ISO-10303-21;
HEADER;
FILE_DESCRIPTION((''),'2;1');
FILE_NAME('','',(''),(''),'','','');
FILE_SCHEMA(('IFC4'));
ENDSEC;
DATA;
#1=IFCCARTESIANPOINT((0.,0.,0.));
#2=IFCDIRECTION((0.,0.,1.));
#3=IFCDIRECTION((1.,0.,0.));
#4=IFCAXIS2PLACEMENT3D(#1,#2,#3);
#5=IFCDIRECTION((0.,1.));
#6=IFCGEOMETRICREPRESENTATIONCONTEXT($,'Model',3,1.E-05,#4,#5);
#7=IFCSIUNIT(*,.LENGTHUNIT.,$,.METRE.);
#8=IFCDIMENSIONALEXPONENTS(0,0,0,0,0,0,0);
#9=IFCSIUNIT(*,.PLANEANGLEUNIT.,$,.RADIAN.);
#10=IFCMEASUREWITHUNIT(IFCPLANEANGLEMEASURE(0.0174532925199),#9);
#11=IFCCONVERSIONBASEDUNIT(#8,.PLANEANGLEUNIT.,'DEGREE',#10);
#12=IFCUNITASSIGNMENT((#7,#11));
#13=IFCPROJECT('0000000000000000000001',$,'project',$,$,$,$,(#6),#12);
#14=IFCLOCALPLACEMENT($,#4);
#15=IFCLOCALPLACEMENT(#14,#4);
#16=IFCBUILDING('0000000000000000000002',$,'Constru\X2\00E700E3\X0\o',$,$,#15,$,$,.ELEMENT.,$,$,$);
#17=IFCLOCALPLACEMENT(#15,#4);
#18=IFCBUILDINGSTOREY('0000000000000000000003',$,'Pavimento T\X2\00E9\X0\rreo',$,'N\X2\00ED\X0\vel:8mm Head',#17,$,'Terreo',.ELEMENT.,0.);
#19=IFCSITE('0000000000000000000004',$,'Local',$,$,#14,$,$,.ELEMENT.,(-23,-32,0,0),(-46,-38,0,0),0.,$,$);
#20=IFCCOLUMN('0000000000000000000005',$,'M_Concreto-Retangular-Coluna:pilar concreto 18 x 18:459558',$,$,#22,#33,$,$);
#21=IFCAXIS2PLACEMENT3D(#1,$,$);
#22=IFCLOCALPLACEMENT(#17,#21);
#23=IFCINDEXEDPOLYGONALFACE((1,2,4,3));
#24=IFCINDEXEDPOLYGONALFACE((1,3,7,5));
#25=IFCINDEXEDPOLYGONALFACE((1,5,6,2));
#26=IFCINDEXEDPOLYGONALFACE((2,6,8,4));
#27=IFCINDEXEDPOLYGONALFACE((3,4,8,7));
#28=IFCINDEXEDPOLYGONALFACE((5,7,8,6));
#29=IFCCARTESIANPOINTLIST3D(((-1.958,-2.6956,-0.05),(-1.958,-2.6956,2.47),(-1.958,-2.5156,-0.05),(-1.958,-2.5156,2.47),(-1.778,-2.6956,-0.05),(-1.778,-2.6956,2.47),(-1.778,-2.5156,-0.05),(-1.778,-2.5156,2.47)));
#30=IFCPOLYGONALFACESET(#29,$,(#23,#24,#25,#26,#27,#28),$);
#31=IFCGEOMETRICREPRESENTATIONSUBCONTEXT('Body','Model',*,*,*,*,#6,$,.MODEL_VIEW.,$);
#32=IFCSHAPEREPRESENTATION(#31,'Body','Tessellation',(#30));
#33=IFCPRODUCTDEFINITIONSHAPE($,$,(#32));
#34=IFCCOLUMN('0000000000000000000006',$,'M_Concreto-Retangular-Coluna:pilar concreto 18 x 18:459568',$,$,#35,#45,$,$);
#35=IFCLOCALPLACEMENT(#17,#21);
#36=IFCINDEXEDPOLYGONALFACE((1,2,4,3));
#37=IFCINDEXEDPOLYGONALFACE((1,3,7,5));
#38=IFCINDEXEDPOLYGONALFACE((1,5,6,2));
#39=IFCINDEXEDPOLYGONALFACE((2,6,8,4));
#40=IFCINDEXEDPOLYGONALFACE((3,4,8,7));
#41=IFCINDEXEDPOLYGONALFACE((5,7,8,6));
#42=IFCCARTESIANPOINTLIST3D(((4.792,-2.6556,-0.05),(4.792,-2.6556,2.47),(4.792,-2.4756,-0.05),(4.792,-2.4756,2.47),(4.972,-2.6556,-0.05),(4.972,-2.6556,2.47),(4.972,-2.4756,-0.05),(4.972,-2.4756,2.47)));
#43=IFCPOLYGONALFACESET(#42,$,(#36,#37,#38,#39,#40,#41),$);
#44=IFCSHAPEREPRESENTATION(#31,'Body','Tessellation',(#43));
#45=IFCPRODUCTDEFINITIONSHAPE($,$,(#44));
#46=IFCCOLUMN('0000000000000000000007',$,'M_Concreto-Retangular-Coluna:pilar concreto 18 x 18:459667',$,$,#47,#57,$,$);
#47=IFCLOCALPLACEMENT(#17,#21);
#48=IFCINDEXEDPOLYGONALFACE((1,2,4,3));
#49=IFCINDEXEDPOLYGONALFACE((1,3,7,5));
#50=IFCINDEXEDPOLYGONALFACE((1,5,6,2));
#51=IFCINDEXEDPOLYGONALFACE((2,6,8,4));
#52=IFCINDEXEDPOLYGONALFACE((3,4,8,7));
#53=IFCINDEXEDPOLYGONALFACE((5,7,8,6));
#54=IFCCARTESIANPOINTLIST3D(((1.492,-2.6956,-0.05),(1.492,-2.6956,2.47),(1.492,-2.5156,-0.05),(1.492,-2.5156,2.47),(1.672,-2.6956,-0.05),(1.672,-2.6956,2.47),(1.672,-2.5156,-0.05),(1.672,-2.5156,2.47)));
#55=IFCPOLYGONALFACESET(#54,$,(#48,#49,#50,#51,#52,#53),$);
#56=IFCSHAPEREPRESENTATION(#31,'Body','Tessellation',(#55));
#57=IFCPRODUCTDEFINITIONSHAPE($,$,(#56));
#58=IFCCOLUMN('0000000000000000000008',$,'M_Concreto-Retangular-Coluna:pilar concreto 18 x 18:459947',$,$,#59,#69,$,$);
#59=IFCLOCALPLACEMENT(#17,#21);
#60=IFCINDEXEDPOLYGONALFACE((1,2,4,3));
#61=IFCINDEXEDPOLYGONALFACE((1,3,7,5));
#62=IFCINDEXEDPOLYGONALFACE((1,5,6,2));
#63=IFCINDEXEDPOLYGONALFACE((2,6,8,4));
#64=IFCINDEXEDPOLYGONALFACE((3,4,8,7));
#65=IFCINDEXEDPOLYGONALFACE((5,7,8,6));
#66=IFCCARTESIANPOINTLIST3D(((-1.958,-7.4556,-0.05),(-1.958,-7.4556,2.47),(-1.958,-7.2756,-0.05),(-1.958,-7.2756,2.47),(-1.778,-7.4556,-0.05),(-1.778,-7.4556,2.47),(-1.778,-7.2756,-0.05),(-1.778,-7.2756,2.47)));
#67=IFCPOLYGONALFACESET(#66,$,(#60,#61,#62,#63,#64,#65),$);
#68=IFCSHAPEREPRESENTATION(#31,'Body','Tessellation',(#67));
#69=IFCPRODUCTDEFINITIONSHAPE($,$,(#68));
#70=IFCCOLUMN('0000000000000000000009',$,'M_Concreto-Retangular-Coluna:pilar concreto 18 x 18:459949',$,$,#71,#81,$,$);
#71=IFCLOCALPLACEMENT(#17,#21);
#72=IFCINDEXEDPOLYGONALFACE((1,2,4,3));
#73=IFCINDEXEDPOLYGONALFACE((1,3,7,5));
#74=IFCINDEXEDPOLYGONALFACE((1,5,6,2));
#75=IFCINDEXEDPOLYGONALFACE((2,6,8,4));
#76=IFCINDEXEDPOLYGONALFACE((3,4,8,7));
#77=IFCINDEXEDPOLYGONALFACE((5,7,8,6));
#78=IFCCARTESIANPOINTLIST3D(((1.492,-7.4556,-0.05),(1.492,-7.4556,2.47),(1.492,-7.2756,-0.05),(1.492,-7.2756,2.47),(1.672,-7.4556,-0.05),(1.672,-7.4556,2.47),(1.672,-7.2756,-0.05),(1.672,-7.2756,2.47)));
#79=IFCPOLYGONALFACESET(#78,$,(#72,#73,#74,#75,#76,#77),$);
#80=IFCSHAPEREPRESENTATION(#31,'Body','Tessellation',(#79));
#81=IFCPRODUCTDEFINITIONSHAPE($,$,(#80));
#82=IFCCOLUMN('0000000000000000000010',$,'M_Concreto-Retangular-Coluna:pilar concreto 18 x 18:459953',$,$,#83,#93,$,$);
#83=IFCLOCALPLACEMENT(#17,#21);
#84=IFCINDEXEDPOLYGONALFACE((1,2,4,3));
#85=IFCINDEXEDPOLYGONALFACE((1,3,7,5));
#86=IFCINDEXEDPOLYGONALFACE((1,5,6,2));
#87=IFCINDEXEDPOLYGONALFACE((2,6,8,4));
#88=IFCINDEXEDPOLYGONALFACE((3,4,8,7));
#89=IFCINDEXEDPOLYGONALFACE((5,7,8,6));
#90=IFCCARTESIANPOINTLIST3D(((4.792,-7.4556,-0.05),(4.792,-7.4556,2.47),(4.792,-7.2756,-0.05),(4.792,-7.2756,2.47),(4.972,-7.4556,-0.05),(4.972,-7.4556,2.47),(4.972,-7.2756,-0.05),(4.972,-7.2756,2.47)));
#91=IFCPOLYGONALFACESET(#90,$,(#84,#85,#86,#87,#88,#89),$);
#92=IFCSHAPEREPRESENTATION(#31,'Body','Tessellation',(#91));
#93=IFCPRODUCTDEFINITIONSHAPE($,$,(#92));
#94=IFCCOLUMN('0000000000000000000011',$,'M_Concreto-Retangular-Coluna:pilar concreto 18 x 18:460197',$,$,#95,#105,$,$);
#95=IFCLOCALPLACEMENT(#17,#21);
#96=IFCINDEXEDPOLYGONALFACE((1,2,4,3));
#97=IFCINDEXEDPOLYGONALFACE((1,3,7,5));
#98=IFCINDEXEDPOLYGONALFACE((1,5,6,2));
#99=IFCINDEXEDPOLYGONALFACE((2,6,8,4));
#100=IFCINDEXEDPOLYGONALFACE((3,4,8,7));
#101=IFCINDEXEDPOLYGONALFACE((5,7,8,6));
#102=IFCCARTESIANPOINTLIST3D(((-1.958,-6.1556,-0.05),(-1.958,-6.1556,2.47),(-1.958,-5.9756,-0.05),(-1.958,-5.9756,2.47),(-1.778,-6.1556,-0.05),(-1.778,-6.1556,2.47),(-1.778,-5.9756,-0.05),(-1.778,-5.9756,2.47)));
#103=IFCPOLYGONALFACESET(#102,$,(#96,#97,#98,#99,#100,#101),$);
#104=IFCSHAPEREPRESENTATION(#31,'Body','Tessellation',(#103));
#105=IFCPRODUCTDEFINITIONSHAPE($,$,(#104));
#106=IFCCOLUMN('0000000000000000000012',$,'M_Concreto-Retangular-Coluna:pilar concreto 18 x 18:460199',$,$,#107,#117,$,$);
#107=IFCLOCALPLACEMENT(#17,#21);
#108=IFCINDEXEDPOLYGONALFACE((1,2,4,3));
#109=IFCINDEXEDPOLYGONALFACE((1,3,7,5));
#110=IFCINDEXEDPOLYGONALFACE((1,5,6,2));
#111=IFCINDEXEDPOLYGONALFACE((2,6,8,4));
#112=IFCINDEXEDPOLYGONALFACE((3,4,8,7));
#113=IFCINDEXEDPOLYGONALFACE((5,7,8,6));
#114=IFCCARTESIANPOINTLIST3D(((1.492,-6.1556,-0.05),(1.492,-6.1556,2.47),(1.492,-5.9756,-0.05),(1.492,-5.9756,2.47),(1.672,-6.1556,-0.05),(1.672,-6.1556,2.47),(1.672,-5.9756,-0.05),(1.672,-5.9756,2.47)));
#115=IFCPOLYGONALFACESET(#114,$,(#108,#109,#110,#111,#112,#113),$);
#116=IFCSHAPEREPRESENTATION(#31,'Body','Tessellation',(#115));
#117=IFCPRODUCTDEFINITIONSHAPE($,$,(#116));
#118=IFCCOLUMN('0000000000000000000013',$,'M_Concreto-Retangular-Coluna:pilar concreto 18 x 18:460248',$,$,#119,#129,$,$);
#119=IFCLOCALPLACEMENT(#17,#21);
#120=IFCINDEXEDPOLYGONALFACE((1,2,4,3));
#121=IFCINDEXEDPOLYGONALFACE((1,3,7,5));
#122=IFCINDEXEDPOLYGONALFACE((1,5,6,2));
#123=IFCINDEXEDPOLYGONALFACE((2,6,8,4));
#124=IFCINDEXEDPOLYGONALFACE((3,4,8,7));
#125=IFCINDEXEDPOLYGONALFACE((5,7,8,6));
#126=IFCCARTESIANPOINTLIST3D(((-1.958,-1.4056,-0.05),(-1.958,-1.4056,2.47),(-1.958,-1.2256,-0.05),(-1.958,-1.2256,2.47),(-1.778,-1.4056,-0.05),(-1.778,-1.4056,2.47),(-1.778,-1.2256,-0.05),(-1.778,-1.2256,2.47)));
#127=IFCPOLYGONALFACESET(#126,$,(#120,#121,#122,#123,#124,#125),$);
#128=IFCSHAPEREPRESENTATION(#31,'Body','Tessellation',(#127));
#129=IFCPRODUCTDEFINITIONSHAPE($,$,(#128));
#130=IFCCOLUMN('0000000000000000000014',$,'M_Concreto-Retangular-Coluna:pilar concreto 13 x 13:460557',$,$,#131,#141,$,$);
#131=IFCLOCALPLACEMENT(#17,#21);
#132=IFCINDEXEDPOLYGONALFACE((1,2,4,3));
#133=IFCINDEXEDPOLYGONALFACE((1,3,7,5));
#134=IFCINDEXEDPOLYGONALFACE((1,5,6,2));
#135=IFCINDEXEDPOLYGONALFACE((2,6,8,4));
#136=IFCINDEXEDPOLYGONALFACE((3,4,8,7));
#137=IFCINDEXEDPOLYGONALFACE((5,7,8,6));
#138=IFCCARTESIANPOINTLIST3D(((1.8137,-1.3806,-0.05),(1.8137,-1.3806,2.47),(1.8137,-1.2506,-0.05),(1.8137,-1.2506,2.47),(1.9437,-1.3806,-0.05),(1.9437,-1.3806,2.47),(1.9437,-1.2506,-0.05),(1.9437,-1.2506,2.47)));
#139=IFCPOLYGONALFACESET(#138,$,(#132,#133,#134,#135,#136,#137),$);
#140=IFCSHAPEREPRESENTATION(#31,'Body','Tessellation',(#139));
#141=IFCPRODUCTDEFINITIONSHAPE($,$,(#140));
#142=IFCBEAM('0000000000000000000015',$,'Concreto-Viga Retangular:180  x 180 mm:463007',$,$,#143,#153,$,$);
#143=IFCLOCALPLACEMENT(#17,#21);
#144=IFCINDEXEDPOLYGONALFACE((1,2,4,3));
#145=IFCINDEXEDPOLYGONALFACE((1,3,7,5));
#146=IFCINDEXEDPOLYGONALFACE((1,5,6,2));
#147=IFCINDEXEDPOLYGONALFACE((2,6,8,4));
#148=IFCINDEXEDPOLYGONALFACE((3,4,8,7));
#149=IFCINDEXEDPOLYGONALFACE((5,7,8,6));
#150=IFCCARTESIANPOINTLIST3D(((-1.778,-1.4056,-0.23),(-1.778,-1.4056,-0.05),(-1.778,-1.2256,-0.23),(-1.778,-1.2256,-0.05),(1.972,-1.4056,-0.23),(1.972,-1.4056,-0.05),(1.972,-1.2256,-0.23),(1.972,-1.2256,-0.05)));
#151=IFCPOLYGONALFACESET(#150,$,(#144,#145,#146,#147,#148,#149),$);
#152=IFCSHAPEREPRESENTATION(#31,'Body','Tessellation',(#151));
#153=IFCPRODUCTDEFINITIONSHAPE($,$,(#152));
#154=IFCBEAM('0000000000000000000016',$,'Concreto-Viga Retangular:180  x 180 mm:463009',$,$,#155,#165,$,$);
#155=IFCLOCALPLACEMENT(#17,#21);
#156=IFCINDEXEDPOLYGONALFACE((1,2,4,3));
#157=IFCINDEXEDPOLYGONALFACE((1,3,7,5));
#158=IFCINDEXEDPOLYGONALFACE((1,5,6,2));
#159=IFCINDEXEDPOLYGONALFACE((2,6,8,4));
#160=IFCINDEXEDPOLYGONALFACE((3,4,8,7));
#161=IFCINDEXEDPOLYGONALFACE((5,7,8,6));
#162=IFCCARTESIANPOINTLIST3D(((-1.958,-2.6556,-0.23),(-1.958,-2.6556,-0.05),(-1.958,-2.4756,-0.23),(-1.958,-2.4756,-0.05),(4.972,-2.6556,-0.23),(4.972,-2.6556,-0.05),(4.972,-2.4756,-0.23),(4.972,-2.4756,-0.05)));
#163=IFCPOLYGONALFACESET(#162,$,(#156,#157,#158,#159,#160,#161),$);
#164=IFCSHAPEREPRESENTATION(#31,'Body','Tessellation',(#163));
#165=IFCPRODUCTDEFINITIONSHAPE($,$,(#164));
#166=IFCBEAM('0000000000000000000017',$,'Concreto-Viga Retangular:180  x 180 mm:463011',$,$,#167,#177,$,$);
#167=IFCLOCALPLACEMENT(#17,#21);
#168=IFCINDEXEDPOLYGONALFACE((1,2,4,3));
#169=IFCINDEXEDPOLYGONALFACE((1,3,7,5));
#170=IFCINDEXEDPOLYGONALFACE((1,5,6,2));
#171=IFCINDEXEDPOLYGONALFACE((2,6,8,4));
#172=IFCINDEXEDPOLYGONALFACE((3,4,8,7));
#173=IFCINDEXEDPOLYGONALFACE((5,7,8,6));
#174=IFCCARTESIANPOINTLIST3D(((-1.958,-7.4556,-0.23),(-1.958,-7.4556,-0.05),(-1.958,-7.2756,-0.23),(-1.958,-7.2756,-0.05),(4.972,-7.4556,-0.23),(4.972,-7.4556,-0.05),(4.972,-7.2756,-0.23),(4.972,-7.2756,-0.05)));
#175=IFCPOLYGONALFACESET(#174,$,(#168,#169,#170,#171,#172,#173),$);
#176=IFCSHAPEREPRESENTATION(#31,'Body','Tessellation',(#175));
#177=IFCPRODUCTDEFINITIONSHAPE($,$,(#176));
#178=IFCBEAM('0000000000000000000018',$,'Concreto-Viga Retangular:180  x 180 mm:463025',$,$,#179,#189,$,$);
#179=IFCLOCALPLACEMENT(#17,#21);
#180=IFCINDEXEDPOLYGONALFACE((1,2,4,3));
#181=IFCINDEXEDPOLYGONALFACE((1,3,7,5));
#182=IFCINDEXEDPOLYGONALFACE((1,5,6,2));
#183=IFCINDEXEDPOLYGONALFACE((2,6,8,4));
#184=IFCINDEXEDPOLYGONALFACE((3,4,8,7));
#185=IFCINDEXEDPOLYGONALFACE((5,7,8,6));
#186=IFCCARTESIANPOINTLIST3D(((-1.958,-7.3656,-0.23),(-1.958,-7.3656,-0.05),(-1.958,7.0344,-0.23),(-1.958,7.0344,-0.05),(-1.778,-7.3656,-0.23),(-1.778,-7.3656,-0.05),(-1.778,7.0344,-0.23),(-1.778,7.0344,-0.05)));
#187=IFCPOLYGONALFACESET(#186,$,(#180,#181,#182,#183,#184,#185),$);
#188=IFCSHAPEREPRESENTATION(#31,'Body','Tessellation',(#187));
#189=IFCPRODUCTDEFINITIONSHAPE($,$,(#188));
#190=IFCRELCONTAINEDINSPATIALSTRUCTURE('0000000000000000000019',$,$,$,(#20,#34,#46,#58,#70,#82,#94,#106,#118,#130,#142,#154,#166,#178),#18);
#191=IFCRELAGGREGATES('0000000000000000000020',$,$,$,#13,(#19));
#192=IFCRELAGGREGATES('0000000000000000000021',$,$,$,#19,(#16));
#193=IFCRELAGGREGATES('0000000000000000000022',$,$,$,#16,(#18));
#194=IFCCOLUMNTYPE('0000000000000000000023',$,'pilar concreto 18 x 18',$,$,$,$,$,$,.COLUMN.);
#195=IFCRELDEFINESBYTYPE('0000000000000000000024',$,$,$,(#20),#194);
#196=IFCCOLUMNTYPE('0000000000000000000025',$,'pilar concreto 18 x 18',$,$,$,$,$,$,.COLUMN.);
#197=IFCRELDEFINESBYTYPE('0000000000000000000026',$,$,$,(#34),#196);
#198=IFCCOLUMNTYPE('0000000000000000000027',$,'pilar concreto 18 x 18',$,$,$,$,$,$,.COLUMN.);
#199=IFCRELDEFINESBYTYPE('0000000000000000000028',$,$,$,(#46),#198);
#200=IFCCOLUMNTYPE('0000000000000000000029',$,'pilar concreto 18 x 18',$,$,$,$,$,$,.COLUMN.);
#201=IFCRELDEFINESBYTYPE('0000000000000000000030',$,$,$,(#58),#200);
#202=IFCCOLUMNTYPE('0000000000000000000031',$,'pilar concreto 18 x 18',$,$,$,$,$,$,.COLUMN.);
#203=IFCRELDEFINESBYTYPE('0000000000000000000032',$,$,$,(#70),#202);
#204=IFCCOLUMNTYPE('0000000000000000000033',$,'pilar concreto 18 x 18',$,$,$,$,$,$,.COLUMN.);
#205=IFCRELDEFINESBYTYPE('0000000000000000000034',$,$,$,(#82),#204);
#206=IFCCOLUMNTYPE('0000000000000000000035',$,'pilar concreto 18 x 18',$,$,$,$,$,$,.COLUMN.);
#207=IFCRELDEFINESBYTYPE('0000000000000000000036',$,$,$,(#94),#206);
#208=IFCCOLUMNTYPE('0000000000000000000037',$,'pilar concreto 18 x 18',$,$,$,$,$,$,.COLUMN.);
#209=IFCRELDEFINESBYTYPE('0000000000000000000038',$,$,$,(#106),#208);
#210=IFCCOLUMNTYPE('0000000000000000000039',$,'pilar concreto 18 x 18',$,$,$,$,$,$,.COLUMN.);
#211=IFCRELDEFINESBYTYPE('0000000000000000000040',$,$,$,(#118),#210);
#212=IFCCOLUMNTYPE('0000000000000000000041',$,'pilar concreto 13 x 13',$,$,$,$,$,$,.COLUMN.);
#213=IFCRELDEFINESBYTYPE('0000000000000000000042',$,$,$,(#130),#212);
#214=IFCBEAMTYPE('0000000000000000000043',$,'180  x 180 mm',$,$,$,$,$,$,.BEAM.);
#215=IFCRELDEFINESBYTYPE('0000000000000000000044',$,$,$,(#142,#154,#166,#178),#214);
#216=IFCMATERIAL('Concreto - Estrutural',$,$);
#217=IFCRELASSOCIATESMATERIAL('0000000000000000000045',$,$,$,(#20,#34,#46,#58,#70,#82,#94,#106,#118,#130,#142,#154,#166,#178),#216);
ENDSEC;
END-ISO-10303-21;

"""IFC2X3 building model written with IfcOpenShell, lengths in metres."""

from ifc_helpers import new_model, entity, si_unit, converted_unit, direction, frame, frame_2d, origin_with_axes, origin_2d_with_axis, place, context, subcontext, project, spatial, rectangle, extrude, material, type_object, element, save


model = new_model("IFC2X3")

# Units and contexts
model_context = context("Model", 3, precision=1e-05, world=origin_with_axes(), true_north=direction((0.0, 1.0)))
body_context = subcontext(model_context, "Body", "Model", "MODEL_VIEW")
ifc_project = project(units=[si_unit("LENGTHUNIT", "METRE"), converted_unit("PLANEANGLEUNIT", "DEGREE", entity("IfcPlaneAngleMeasure", 0.0174532925199), si_unit("PLANEANGLEUNIT", "RADIAN"), dimensions=[0, 0, 0, 0, 0, 0, 0])], contexts=[model_context])

# Site, building, storey
site_placement = place(None, origin_with_axes())
site = spatial("IfcSite", under=ifc_project, at=site_placement, Name="Local", CompositionType="ELEMENT", RefLatitude=(-23, -32, 0, 0), RefLongitude=(-46, -38, 0, 0), RefElevation=0.0)
building_placement = place(site_placement, origin_with_axes())
building = spatial("IfcBuilding", under=site, at=building_placement, Name="Construção", CompositionType="ELEMENT")
storey_placement = place(building_placement, origin_with_axes())
storey = spatial("IfcBuildingStorey", under=building, at=storey_placement, Name="Pavimento Térreo", ObjectType="Nível:8mm Head", LongName="Terreo", CompositionType="ELEMENT", Elevation=0.0)

# Shared definitions
ifc_material = material(Name="Concreto - Estrutural")

# Columns
column_type_1 = type_object("IfcColumnType", Name="pilar concreto 18 x 18", PredefinedType="COLUMN")
column_1_placement = place(storey_placement, frame((-1.868, -2.6056, -0.05), z_axis=(0.0, 0.0, 1.0), x_axis=(0.0, -1.0, 0.0)))
element("IfcColumn", 1, at=column_1_placement, inside=storey, type_object=column_type_1, material=ifc_material, Name="M_Concreto-Retangular-Coluna:pilar concreto 18 x 18:459558", context=body_context, shape_type="SweptSolid", body=[
    extrude(rectangle(XDim=0.18, YDim=0.18, at=origin_2d_with_axis()), origin_with_axes(), (0.0, 0.0, 1.0), 2.52),
])
column_type_2 = type_object("IfcColumnType", Name="pilar concreto 18 x 18", PredefinedType="COLUMN")
column_2_placement = place(storey_placement, frame((4.882, -2.5656, -0.05), z_axis=(0.0, 0.0, 1.0), x_axis=(0.0, -1.0, 0.0)))
element("IfcColumn", 2, at=column_2_placement, inside=storey, type_object=column_type_2, material=ifc_material, Name="M_Concreto-Retangular-Coluna:pilar concreto 18 x 18:459568", context=body_context, shape_type="SweptSolid", body=[
    extrude(rectangle(XDim=0.18, YDim=0.18, at=origin_2d_with_axis()), origin_with_axes(), (0.0, 0.0, 1.0), 2.52),
])
column_type_3 = type_object("IfcColumnType", Name="pilar concreto 18 x 18", PredefinedType="COLUMN")
column_3_placement = place(storey_placement, frame((1.582, -2.6056, -0.05), z_axis=(0.0, 0.0, 1.0), x_axis=(0.0, -1.0, 0.0)))
element("IfcColumn", 3, at=column_3_placement, inside=storey, type_object=column_type_3, material=ifc_material, Name="M_Concreto-Retangular-Coluna:pilar concreto 18 x 18:459667", context=body_context, shape_type="SweptSolid", body=[
    extrude(rectangle(XDim=0.18, YDim=0.18, at=origin_2d_with_axis()), origin_with_axes(), (0.0, 0.0, 1.0), 2.52),
])
column_type_4 = type_object("IfcColumnType", Name="pilar concreto 18 x 18", PredefinedType="COLUMN")
column_4_placement = place(storey_placement, frame((-1.868, -7.3656, -0.05), z_axis=(0.0, 0.0, 1.0), x_axis=(0.0, -1.0, 0.0)))
element("IfcColumn", 4, at=column_4_placement, inside=storey, type_object=column_type_4, material=ifc_material, Name="M_Concreto-Retangular-Coluna:pilar concreto 18 x 18:459947", context=body_context, shape_type="SweptSolid", body=[
    extrude(rectangle(XDim=0.18, YDim=0.18, at=origin_2d_with_axis()), origin_with_axes(), (0.0, 0.0, 1.0), 2.52),
])
column_type_5 = type_object("IfcColumnType", Name="pilar concreto 18 x 18", PredefinedType="COLUMN")
column_5_placement = place(storey_placement, frame((1.582, -7.3656, -0.05), z_axis=(0.0, 0.0, 1.0), x_axis=(0.0, -1.0, 0.0)))
element("IfcColumn", 5, at=column_5_placement, inside=storey, type_object=column_type_5, material=ifc_material, Name="M_Concreto-Retangular-Coluna:pilar concreto 18 x 18:459949", context=body_context, shape_type="SweptSolid", body=[
    extrude(rectangle(XDim=0.18, YDim=0.18, at=origin_2d_with_axis()), origin_with_axes(), (0.0, 0.0, 1.0), 2.52),
])
column_type_6 = type_object("IfcColumnType", Name="pilar concreto 18 x 18", PredefinedType="COLUMN")
column_6_placement = place(storey_placement, frame((4.882, -7.3656, -0.05), z_axis=(0.0, 0.0, 1.0), x_axis=(0.0, -1.0, 0.0)))
element("IfcColumn", 6, at=column_6_placement, inside=storey, type_object=column_type_6, material=ifc_material, Name="M_Concreto-Retangular-Coluna:pilar concreto 18 x 18:459953", context=body_context, shape_type="SweptSolid", body=[
    extrude(rectangle(XDim=0.18, YDim=0.18, at=origin_2d_with_axis()), origin_with_axes(), (0.0, 0.0, 1.0), 2.52),
])
column_type_7 = type_object("IfcColumnType", Name="pilar concreto 18 x 18", PredefinedType="COLUMN")
column_7_placement = place(storey_placement, frame((-1.868, -6.0656, -0.05), z_axis=(0.0, 0.0, 1.0), x_axis=(0.0, -1.0, 0.0)))
element("IfcColumn", 7, at=column_7_placement, inside=storey, type_object=column_type_7, material=ifc_material, Name="M_Concreto-Retangular-Coluna:pilar concreto 18 x 18:460197", context=body_context, shape_type="SweptSolid", body=[
    extrude(rectangle(XDim=0.18, YDim=0.18, at=origin_2d_with_axis()), origin_with_axes(), (0.0, 0.0, 1.0), 2.52),
])
column_type_8 = type_object("IfcColumnType", Name="pilar concreto 18 x 18", PredefinedType="COLUMN")
column_8_placement = place(storey_placement, frame((1.582, -6.0656, -0.05), z_axis=(0.0, 0.0, 1.0), x_axis=(0.0, -1.0, 0.0)))
element("IfcColumn", 8, at=column_8_placement, inside=storey, type_object=column_type_8, material=ifc_material, Name="M_Concreto-Retangular-Coluna:pilar concreto 18 x 18:460199", context=body_context, shape_type="SweptSolid", body=[
    extrude(rectangle(XDim=0.18, YDim=0.18, at=origin_2d_with_axis()), origin_with_axes(), (0.0, 0.0, 1.0), 2.52),
])
column_type_9 = type_object("IfcColumnType", Name="pilar concreto 18 x 18", PredefinedType="COLUMN")
column_9_placement = place(storey_placement, frame((-1.868, -1.3156, -0.05), z_axis=(0.0, 0.0, 1.0), x_axis=(0.0, -1.0, 0.0)))
element("IfcColumn", 9, at=column_9_placement, inside=storey, type_object=column_type_9, material=ifc_material, Name="M_Concreto-Retangular-Coluna:pilar concreto 18 x 18:460248", context=body_context, shape_type="SweptSolid", body=[
    extrude(rectangle(XDim=0.18, YDim=0.18, at=origin_2d_with_axis()), origin_with_axes(), (0.0, 0.0, 1.0), 2.52),
])
column_type_10 = type_object("IfcColumnType", Name="pilar concreto 13 x 13", PredefinedType="COLUMN")
column_10_placement = place(storey_placement, frame((1.8787, -1.3156, -0.05), z_axis=(0.0, 0.0, 1.0), x_axis=(0.0, -1.0, 0.0)))
element("IfcColumn", 10, at=column_10_placement, inside=storey, type_object=column_type_10, material=ifc_material, Name="M_Concreto-Retangular-Coluna:pilar concreto 13 x 13:460557", context=body_context, shape_type="SweptSolid", body=[
    extrude(rectangle(XDim=0.13, YDim=0.13, at=origin_2d_with_axis()), origin_with_axes(), (0.0, 0.0, 1.0), 2.52),
])

# Beams
beam_type_1 = type_object("IfcBeamType", Name="180  x 180 mm", PredefinedType="BEAM")
beam_1_placement = place(storey_placement, frame((1.972, -1.3156, -0.05), z_axis=(0.0, 0.0, 1.0), x_axis=(0.0, 1.0, 0.0)))
element("IfcBeam", 11, at=beam_1_placement, inside=storey, type_object=beam_type_1, material=ifc_material, Name="Concreto-Viga Retangular:180  x 180 mm:463007", context=body_context, shape_type="SweptSolid", body=[
    extrude(rectangle(XDim=0.18, YDim=0.18, at=frame_2d((-0.09, 0.0), x_axis=(1.0, 0.0))), frame((0.0, 0.0, 0.0), z_axis=(0.0, 1.0, 0.0), x_axis=(0.0, 0.0, 1.0)), (0.0, 0.0, 1.0), 3.75),
])
for number, where, z_axis, x_axis, name in (
    (12, (4.972, -2.5656, -0.05), (0.0, 0.0, 1.0), (0.0, 1.0, 0.0), "Concreto-Viga Retangular:180  x 180 mm:463009"),
    (13, (4.972, -7.3656, -0.05), (0.0, 0.0, 1.0), (0.0, 1.0, 0.0), "Concreto-Viga Retangular:180  x 180 mm:463011"),
):
    element("IfcBeam", number, at=place(storey_placement, frame(where, z_axis=z_axis, x_axis=x_axis)), inside=storey, type_object=beam_type_1, material=ifc_material, Name=name, context=body_context, shape_type="SweptSolid", body=[
        extrude(rectangle(XDim=0.18, YDim=0.18, at=frame_2d((-0.09, 0.0), x_axis=(1.0, 0.0))), frame((0.0, 0.0, 0.0), z_axis=(0.0, 1.0, 0.0), x_axis=(0.0, 0.0, 1.0)), (0.0, 0.0, 1.0), 6.93),
    ])
beam_2_placement = place(storey_placement, frame((-1.868, -7.3656, -0.05), z_axis=(0.0, 0.0, 1.0), x_axis=(1.0, 0.0, 0.0)))
element("IfcBeam", 14, at=beam_2_placement, inside=storey, type_object=beam_type_1, material=ifc_material, Name="Concreto-Viga Retangular:180  x 180 mm:463025", context=body_context, shape_type="SweptSolid", body=[
    extrude(rectangle(XDim=0.18, YDim=0.18, at=frame_2d((-0.09, 0.0), x_axis=(1.0, 0.0))), frame((0.0, 0.0, 0.0), z_axis=(0.0, 1.0, 0.0), x_axis=(0.0, 0.0, 1.0)), (0.0, 0.0, 1.0), 14.4),
])

save(model, "model.ifc")
